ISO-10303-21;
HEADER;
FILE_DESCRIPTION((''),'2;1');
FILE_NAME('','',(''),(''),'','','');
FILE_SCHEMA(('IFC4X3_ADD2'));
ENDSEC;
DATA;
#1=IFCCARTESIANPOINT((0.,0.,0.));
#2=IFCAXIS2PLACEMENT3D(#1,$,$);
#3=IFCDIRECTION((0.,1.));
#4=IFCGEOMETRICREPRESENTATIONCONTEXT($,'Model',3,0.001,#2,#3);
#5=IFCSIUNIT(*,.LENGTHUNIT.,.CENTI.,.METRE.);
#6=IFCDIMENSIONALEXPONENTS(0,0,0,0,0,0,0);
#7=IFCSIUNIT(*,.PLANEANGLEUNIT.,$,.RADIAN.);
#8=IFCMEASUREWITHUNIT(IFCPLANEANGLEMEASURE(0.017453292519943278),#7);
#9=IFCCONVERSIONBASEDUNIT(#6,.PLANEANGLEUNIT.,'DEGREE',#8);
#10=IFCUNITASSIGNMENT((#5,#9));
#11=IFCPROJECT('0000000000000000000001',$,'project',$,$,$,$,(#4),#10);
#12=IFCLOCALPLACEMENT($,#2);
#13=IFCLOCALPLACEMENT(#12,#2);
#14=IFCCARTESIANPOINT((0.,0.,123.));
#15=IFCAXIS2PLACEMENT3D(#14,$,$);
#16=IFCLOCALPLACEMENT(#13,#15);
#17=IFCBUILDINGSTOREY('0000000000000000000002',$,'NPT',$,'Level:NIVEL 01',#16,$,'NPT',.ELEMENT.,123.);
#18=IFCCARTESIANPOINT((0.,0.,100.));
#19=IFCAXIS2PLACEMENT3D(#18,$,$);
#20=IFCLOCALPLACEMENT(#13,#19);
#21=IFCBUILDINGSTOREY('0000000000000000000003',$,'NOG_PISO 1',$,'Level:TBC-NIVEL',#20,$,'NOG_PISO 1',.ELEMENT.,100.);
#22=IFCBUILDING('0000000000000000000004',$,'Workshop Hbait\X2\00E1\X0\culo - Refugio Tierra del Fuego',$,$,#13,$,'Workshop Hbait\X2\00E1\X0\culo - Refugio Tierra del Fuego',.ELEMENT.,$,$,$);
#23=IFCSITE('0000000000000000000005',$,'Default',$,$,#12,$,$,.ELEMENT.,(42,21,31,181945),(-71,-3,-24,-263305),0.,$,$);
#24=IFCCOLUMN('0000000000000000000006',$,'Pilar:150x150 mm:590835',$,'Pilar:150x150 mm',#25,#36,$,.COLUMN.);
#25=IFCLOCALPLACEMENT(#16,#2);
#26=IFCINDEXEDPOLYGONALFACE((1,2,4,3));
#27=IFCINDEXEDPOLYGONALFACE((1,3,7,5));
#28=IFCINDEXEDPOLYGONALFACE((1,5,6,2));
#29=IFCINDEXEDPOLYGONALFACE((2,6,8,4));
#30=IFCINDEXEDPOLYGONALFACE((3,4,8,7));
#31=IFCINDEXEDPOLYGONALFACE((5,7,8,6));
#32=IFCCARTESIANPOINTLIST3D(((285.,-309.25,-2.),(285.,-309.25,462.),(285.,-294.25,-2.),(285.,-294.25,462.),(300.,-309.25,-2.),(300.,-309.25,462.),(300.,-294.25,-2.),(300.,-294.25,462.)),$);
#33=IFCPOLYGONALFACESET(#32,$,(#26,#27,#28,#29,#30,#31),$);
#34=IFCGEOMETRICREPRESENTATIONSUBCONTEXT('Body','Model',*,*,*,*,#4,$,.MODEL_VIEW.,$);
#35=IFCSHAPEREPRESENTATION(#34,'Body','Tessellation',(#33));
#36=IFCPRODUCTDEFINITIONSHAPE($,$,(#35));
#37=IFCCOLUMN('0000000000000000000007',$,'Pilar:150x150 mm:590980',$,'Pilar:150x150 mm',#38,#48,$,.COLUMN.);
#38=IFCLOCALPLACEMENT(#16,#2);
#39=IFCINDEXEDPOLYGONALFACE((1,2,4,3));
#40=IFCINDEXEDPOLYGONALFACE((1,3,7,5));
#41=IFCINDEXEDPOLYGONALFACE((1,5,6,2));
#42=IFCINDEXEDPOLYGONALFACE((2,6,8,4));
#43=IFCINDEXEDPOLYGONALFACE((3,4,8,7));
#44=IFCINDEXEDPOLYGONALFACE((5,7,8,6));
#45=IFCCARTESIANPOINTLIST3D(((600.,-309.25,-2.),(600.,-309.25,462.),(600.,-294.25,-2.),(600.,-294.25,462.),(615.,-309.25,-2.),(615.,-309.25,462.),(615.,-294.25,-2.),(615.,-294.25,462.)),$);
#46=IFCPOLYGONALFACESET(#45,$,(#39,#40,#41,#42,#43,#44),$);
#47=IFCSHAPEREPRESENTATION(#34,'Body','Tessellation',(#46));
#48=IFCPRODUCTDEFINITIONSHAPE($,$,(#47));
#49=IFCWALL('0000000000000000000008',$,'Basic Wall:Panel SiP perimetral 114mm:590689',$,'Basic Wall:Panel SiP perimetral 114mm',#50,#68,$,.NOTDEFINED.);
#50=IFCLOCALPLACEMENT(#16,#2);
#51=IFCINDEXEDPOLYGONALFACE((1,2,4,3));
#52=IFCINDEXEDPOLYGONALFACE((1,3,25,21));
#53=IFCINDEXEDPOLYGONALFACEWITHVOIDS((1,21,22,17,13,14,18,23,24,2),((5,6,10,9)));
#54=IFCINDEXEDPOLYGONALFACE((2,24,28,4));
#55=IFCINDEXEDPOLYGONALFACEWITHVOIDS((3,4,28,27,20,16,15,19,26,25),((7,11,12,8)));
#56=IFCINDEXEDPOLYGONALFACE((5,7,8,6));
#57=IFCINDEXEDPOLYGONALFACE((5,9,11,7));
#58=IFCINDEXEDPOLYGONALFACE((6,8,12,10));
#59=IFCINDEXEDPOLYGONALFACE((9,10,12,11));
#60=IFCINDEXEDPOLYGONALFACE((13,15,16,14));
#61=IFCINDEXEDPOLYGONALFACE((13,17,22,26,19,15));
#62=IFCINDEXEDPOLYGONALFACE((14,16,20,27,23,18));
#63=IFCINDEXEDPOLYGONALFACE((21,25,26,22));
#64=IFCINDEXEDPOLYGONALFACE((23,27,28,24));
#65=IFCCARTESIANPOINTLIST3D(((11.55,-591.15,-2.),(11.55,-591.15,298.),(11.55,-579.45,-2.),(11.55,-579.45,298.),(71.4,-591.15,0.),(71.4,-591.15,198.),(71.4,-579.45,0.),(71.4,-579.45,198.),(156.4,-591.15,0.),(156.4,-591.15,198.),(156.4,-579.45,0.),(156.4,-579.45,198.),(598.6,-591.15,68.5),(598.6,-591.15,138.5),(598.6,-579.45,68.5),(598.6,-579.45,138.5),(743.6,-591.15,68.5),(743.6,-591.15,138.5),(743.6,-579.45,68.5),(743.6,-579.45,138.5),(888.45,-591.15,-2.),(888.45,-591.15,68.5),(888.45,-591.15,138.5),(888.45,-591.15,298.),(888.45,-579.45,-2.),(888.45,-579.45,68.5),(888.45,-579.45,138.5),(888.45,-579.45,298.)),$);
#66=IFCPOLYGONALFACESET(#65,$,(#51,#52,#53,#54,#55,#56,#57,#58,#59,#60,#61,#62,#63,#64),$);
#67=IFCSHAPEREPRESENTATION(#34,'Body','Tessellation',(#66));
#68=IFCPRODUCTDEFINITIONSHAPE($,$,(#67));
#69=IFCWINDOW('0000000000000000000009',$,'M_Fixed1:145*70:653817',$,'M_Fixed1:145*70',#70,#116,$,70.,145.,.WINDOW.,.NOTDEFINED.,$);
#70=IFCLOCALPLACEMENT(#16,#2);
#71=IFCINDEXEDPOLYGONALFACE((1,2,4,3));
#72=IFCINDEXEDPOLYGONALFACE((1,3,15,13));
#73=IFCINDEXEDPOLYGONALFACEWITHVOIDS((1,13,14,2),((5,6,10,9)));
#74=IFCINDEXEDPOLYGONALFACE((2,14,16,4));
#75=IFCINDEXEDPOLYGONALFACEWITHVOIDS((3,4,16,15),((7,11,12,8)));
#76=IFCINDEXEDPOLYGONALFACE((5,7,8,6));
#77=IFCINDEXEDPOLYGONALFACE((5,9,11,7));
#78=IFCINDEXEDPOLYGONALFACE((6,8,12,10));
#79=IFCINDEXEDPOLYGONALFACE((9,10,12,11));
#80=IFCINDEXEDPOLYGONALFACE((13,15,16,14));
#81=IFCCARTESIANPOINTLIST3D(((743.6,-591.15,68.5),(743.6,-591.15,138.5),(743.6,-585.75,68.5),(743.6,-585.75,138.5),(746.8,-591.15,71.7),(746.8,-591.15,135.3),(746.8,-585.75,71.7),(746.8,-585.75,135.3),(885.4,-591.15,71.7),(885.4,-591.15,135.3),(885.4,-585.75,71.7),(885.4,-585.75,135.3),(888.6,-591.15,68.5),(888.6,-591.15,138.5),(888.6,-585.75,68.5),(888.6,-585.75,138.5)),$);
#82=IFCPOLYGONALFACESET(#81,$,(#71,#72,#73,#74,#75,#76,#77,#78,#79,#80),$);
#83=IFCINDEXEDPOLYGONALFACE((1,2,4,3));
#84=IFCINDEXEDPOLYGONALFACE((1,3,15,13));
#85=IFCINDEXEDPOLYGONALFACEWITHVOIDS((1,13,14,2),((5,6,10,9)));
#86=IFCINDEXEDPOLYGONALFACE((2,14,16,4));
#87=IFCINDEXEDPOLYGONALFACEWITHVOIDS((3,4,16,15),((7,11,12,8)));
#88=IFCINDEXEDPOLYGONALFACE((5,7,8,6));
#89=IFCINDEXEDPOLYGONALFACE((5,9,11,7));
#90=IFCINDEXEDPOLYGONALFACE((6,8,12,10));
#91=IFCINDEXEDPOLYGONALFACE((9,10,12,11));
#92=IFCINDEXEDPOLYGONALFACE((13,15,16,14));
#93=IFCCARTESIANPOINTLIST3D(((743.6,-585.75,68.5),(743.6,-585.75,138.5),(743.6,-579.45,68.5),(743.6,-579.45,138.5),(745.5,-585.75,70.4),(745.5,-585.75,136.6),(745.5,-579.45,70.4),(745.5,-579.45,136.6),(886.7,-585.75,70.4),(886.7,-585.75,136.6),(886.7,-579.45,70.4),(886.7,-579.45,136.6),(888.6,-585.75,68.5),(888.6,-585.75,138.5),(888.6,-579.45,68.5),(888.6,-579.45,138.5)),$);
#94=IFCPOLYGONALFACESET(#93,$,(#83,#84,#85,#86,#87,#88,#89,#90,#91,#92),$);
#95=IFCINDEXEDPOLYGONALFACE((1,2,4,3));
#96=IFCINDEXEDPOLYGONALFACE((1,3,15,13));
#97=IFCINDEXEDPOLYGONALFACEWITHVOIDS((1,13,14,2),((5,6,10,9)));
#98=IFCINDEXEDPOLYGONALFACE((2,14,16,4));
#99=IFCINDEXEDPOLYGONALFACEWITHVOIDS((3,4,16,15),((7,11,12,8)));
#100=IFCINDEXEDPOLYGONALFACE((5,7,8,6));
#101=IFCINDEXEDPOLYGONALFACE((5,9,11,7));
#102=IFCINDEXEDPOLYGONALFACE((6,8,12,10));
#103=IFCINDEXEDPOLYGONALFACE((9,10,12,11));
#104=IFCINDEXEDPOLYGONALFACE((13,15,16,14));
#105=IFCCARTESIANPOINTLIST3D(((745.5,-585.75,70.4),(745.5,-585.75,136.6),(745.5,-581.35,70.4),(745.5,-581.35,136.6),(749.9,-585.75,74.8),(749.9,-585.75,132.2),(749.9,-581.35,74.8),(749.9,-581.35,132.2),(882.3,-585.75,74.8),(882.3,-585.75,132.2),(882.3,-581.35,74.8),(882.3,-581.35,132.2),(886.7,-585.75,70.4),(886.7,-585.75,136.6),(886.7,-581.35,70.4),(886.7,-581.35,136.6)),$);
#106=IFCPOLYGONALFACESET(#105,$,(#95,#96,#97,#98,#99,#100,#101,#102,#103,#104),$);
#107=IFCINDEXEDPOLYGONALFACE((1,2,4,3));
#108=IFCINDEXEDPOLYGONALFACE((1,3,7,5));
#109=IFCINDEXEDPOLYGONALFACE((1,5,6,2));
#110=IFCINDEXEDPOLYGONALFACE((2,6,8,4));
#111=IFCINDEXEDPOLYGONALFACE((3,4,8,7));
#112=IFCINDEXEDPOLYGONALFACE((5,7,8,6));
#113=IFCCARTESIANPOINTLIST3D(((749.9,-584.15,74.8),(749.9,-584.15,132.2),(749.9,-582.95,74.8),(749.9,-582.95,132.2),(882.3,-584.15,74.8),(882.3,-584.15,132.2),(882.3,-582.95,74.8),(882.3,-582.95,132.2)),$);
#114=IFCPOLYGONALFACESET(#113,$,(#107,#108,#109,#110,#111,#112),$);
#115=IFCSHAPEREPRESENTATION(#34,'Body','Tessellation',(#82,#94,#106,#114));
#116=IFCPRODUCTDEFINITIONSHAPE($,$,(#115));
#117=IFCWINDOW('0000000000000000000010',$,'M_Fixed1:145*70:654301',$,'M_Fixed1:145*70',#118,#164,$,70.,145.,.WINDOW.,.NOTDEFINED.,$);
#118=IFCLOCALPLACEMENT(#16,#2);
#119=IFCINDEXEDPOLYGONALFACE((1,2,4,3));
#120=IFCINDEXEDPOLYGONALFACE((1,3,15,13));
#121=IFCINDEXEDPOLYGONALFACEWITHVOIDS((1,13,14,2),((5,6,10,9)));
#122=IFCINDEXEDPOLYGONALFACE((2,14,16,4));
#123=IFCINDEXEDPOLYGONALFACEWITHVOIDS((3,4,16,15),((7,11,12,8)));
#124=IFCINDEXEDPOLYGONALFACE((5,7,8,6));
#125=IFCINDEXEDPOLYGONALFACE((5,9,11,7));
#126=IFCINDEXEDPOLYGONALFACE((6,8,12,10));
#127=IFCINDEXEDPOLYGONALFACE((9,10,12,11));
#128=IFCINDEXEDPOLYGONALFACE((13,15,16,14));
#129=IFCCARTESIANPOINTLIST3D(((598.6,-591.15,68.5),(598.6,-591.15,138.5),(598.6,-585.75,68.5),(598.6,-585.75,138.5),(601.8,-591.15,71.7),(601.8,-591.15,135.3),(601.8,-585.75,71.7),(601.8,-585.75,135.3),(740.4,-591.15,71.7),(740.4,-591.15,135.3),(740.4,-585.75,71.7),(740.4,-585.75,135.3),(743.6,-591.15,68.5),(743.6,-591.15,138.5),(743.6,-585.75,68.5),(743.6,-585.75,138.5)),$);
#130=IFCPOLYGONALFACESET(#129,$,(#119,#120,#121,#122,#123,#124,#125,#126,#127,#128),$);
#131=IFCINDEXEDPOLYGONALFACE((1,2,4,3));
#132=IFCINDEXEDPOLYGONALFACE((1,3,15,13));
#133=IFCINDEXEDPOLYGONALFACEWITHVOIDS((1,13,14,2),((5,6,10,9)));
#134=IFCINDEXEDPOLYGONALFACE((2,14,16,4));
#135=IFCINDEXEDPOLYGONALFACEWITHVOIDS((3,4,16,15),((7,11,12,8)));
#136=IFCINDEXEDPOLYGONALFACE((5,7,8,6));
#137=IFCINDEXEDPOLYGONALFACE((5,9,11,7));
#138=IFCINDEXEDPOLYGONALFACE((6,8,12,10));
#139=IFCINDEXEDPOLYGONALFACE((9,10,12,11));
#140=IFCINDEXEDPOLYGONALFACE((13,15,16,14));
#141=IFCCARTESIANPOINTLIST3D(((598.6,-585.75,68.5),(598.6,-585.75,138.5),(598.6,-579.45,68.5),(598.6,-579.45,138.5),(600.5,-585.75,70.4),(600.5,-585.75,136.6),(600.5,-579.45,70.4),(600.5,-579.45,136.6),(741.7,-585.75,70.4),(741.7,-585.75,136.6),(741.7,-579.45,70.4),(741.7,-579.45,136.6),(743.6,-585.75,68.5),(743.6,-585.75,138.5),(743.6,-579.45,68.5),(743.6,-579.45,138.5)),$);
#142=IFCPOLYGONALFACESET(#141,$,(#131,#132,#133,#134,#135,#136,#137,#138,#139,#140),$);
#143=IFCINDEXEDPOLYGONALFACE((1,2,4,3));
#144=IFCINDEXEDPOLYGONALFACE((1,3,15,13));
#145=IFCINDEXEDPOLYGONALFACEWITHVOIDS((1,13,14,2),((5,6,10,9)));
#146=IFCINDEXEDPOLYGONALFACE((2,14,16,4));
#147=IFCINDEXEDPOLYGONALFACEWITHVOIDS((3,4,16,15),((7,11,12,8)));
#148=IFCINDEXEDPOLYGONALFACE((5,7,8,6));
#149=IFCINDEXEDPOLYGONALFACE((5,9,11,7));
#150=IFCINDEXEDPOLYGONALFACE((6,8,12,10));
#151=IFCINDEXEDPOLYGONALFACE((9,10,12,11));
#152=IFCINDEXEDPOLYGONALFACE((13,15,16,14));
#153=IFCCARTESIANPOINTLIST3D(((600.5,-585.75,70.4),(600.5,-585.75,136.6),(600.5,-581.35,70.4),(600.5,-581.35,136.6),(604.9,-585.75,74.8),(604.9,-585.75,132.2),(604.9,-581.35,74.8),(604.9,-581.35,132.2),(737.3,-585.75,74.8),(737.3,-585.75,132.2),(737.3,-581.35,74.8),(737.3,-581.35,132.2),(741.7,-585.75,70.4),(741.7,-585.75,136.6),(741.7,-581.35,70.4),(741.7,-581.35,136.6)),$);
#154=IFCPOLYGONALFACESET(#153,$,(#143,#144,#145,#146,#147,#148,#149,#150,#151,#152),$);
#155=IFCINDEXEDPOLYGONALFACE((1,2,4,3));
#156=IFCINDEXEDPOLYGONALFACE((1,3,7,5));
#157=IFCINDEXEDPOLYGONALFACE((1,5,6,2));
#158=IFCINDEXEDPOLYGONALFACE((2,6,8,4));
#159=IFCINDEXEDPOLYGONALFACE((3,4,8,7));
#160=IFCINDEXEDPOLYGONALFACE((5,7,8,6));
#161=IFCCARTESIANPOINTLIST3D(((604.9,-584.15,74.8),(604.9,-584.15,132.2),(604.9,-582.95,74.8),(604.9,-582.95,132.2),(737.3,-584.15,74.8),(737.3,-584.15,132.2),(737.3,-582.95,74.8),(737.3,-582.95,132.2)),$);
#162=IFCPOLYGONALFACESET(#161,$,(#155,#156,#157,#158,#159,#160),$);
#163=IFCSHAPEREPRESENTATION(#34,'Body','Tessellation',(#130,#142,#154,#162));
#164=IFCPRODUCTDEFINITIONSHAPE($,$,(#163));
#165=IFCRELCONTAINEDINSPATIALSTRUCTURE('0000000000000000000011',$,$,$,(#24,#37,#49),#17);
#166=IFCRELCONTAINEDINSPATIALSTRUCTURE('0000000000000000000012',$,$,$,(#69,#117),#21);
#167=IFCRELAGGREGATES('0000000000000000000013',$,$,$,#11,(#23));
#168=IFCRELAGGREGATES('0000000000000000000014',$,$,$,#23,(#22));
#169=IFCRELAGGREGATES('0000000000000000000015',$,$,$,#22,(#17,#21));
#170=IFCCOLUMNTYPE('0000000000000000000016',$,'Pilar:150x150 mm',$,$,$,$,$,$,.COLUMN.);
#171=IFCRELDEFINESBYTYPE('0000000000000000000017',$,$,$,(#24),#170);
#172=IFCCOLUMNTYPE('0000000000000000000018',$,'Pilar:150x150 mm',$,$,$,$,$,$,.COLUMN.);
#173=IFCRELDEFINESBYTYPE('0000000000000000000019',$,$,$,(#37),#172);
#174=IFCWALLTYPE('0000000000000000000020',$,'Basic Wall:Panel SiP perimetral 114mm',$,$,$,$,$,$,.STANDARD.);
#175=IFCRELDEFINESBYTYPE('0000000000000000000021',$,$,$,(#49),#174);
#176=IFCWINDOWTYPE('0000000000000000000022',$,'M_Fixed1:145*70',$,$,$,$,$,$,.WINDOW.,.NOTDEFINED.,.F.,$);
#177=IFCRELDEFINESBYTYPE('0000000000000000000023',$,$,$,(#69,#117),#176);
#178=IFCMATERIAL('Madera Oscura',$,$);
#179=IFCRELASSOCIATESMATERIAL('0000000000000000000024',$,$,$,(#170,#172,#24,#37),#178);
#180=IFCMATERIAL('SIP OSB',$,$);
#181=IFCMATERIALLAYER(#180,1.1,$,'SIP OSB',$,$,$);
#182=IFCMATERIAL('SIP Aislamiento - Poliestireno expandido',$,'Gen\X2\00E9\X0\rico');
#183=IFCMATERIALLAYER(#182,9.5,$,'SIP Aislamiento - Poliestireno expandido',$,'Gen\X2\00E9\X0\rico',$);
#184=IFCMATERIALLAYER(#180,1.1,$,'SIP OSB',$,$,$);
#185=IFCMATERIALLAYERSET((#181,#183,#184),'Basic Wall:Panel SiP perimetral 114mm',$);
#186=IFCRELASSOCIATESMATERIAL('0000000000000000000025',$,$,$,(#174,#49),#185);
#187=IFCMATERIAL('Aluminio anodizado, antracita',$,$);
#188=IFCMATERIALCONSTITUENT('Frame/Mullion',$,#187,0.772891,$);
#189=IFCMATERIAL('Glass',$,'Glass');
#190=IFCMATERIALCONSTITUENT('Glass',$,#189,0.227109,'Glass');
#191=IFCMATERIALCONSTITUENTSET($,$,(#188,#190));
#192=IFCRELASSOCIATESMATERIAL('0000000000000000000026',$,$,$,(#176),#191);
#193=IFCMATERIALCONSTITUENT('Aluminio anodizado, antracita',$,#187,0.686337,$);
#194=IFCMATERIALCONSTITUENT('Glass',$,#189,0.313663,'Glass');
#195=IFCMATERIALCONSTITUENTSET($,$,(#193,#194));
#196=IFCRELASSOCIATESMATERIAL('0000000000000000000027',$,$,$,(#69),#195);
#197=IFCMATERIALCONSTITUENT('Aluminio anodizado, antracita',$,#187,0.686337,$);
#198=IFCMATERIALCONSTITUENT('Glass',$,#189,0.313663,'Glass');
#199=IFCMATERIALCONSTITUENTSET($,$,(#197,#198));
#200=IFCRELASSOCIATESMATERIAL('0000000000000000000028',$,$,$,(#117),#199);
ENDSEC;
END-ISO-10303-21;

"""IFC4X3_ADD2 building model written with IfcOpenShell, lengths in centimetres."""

from ifc_helpers import new_model, entity, si_unit, converted_unit, direction, frame, frame_2d, origin, origin_2d_with_axis, place, context, subcontext, project, spatial, polyline, rectangle, outline, extrude, source, transform, mapped, material, layer, layer_set, constituent, constituent_set, material_profile, profile_set, profile_usage, type_object, type_shapes, element, fill, save


model = new_model("IFC4X3_ADD2")

# Units and contexts
model_context = context("Model", 3, precision=0.001, world=origin(), true_north=direction((0.0, 1.0)))
body_context = subcontext(model_context, "Body", "Model", "MODEL_VIEW")
ifc_project = project(units=[si_unit("LENGTHUNIT", "METRE", prefix="CENTI"), converted_unit("PLANEANGLEUNIT", "DEGREE", entity("IfcPlaneAngleMeasure", 0.017453292519943278), si_unit("PLANEANGLEUNIT", "RADIAN"), dimensions=[0, 0, 0, 0, 0, 0, 0])], contexts=[model_context])

# Site, building, storey
site_placement = place(None, origin())
site = spatial("IfcSite", under=ifc_project, at=site_placement, Name="Default", CompositionType="ELEMENT", RefLatitude=(42, 21, 31, 181945), RefLongitude=(-71, -3, -24, -263305), RefElevation=0.0)
building_placement = place(site_placement, origin())
building = spatial("IfcBuilding", under=site, at=building_placement, Name="Workshop Hbaitáculo - Refugio Tierra del Fuego", LongName="Workshop Hbaitáculo - Refugio Tierra del Fuego", CompositionType="ELEMENT")
storey_1_placement = place(building_placement, frame((0.0, 0.0, 123.0)))
storey_1 = spatial("IfcBuildingStorey", under=building, at=storey_1_placement, Name="NPT", ObjectType="Level:NIVEL 01", LongName="NPT", CompositionType="ELEMENT", Elevation=123.0)

# Columns
ifc_material_1 = material(Name="Madera Oscura")
ifc_material_profile = material_profile(ifc_material_1, rectangle(XDim=15.0, YDim=15.0, at=origin_2d_with_axis()), Name="150x150 mm")
ifc_profile_set = profile_set([ifc_material_profile], Name="150x150 mm")
ifc_profile_usage = profile_usage(ifc_profile_set)
column_type_1 = type_object("IfcColumnType", Name="Pilar:150x150 mm", PredefinedType="COLUMN", material=ifc_profile_set)
shared_shape_1 = source(origin(), body_context, "Body", "SweptSolid", [
    extrude(rectangle(XDim=15.0, YDim=15.0, at=origin_2d_with_axis()), frame((7.5, 7.5, 0.0), z_axis=(0.0, 0.0, 1.0), x_axis=(0.0, 1.0, 0.0)), (0.0, 0.0, 1.0), 464.0),
])
type_shapes(column_type_1, [shared_shape_1])
column_1_placement = place(storey_1_placement, frame((285.0, -309.25, -2.0)))
element("IfcColumn", 1, at=column_1_placement, inside=storey_1, type_object=column_type_1, material=ifc_profile_usage, Name="Pilar:150x150 mm:590835", ObjectType="Pilar:150x150 mm", PredefinedType="COLUMN", context=body_context, shape_type="MappedRepresentation", body=[
    mapped(shared_shape_1, transform((0.0, 0.0, 0.0), scale=1.0)),
])
column_type_2 = type_object("IfcColumnType", Name="Pilar:150x150 mm", PredefinedType="COLUMN", material=ifc_profile_set)
shared_shape_2 = source(origin(), body_context, "Body", "SweptSolid", [
    extrude(rectangle(XDim=15.0, YDim=15.0, at=origin_2d_with_axis()), frame((7.5, 7.5, 0.0), z_axis=(0.0, 0.0, 1.0), x_axis=(-1.0, 0.0, 0.0)), (0.0, 0.0, 1.0), 464.0),
])
type_shapes(column_type_2, [shared_shape_2])
column_2_placement = place(storey_1_placement, frame((615.0, -294.25, -2.0), z_axis=(0.0, 0.0, 1.0), x_axis=(-1.0, 0.0, 0.0)))
element("IfcColumn", 2, at=column_2_placement, inside=storey_1, type_object=column_type_2, material=ifc_profile_usage, Name="Pilar:150x150 mm:590980", ObjectType="Pilar:150x150 mm", PredefinedType="COLUMN", context=body_context, shape_type="MappedRepresentation", body=[
    mapped(shared_shape_2, transform((0.0, 0.0, 0.0), scale=1.0)),
])

# Wall, openings
ifc_material_2 = material(Name="SIP OSB")
ifc_layer_1 = layer(ifc_material_2, 1.1, Name="SIP OSB")
ifc_material_3 = material(Name="SIP Aislamiento - Poliestireno expandido", Category="Genérico")
ifc_layer_2 = layer(ifc_material_3, 9.5, Name="SIP Aislamiento - Poliestireno expandido", Category="Genérico")
ifc_layer_3 = layer(ifc_material_2, 1.1, Name="SIP OSB")
ifc_layer_set_1 = layer_set([ifc_layer_1, ifc_layer_2, ifc_layer_3], Name="Basic Wall:Panel SiP perimetral 114mm")
wall_type_1 = type_object("IfcWallType", Name="Basic Wall:Panel SiP perimetral 114mm", PredefinedType="STANDARD", material=ifc_layer_set_1)
wall_1_placement = place(storey_1_placement, frame((11.55, -585.3, -2.0)))
wall_1 = element("IfcWall", 3, at=wall_1_placement, inside=storey_1, type_object=wall_type_1, material=ifc_layer_set_1, Name="Basic Wall:Panel SiP perimetral 114mm:590689", ObjectType="Basic Wall:Panel SiP perimetral 114mm", PredefinedType="NOTDEFINED", context=body_context, shape_type="SweptSolid", body=[
    extrude(rectangle(XDim=876.9, YDim=11.7, at=frame_2d((438.45, 0.0), x_axis=(-1.0, 0.0))), origin(), (0.0, 0.0, 1.0), 300.0),
])
opening_1_placement = place(wall_1_placement, frame((732.05, -5.85, 70.5)))
opening_1 = element("IfcOpeningElement", 4, at=opening_1_placement, cuts=wall_1, PredefinedType="OPENING", context=body_context, shape_type="SweptSolid", body=[
    extrude(rectangle(XDim=70.0, YDim=145.0, at=frame_2d((35.0, 72.5), x_axis=(1.0, 0.0))), frame((0.0, 0.0, 0.0), z_axis=(0.0, 1.0, 0.0), x_axis=(0.0, 0.0, 1.0)), (0.0, 0.0, 1.0), 11.7),
])
opening_2_placement = place(wall_1_placement, frame((587.05, -5.85, 70.5)))
opening_2 = element("IfcOpeningElement", 5, at=opening_2_placement, cuts=wall_1, PredefinedType="OPENING", context=body_context, shape_type="SweptSolid", body=[
    extrude(rectangle(XDim=70.0, YDim=145.0, at=frame_2d((35.0, 72.5), x_axis=(1.0, 0.0))), frame((0.0, 0.0, 0.0), z_axis=(0.0, 1.0, 0.0), x_axis=(0.0, 0.0, 1.0)), (0.0, 0.0, 1.0), 11.7),
])
opening_3_placement = place(wall_1_placement, frame((59.85, -5.85, 2.0)))
element("IfcOpeningElement", 6, at=opening_3_placement, cuts=wall_1, PredefinedType="OPENING", context=body_context, shape_type="SweptSolid", body=[
    extrude(rectangle(XDim=198.0, YDim=85.0, at=frame_2d((99.0, 42.5), x_axis=(1.0, 0.0))), frame((0.0, 0.0, 0.0), z_axis=(0.0, 1.0, 0.0), x_axis=(0.0, 0.0, 1.0)), (0.0, 0.0, 1.0), 11.7),
])

# Shared definitions
storey_2_placement = place(building_placement, frame((0.0, 0.0, 100.0)))
storey_2 = spatial("IfcBuildingStorey", under=building, at=storey_2_placement, Name="NOG_PISO 1", ObjectType="Level:TBC-NIVEL", LongName="NOG_PISO 1", CompositionType="ELEMENT", Elevation=100.0)

# Windows
ifc_material_4 = material(Name="Aluminio anodizado, antracita")
ifc_constituent_1 = constituent(ifc_material_4, Name="Aluminio anodizado, antracita", fraction=0.686337)
ifc_material_5 = material(Name="Glass", Category="Glass")
ifc_constituent_2 = constituent(ifc_material_5, Name="Glass", Category="Glass", fraction=0.313663)
ifc_constituent_set_1 = constituent_set(constituents=[ifc_constituent_1, ifc_constituent_2])
ifc_constituent_3 = constituent(ifc_material_4, Name="Frame/Mullion", fraction=0.772891)
ifc_constituent_4 = constituent(ifc_material_5, Name="Glass", Category="Glass", fraction=0.227109)
ifc_constituent_set_2 = constituent_set(constituents=[ifc_constituent_3, ifc_constituent_4])
window_type = type_object("IfcWindowType", Name="M_Fixed1:145*70", ParameterTakesPrecedence=False, PartitioningType="NOTDEFINED", PredefinedType="WINDOW", material=ifc_constituent_set_2)
shared_shape_3 = source(origin(), body_context, "Body", "SweptSolid", [
    extrude(outline(polyline([(-72.5, -35.0), (72.5, -35.0), (72.5, 35.0), (-72.5, 35.0), (-72.5, -35.0)]), holes=[polyline([(-69.3, -31.8), (-69.3, 31.8), (69.3, 31.8), (69.3, -31.8), (-69.3, -31.8)])]), frame((72.5, 0.0, 35.0), z_axis=(0.0, 1.0, 0.0), x_axis=(1.0, 0.0, 0.0)), (0.0, 0.0, 1.0), 5.4),
    extrude(outline(polyline([(-72.5, -35.0), (72.5, -35.0), (72.5, 35.0), (-72.5, 35.0), (-72.5, -35.0)]), holes=[polyline([(-70.6, -33.1), (-70.6, 33.1), (70.6, 33.1), (70.6, -33.1), (-70.6, -33.1)])]), frame((72.5, 5.4, 35.0), z_axis=(0.0, 1.0, 0.0), x_axis=(1.0, 0.0, 0.0)), (0.0, 0.0, 1.0), 6.3),
    extrude(outline(polyline([(-70.6, -33.1), (70.6, -33.1), (70.6, 33.1), (-70.6, 33.1), (-70.6, -33.1)]), holes=[polyline([(-66.2, -28.7), (-66.2, 28.7), (66.2, 28.7), (66.2, -28.7), (-66.2, -28.7)])]), frame((72.5, 5.4, 35.0), z_axis=(0.0, 1.0, 0.0), x_axis=(1.0, 0.0, 0.0)), (0.0, 0.0, 1.0), 4.4),
    extrude(rectangle(XDim=1.2, YDim=132.4, at=origin_2d_with_axis()), frame((72.5, 7.6, 6.3), z_axis=(0.0, 0.0, 1.0), x_axis=(0.0, -1.0, 0.0)), (0.0, 0.0, 1.0), 57.4),
])
type_shapes(window_type, [shared_shape_3])
window_1_placement = place(opening_1_placement, origin())
window_1 = element("IfcWindow", 7, at=window_1_placement, inside=storey_2, type_object=window_type, material=ifc_constituent_set_1, Name="M_Fixed1:145*70:653817", ObjectType="M_Fixed1:145*70", OverallHeight=70.0, OverallWidth=145.0, PartitioningType="NOTDEFINED", PredefinedType="WINDOW", context=body_context, shape_type="MappedRepresentation", body=[
    mapped(shared_shape_3, transform((0.0, 0.0, 0.0), scale=1.0)),
])
fill(opening_1, window_1)
ifc_constituent_5 = constituent(ifc_material_4, Name="Aluminio anodizado, antracita", fraction=0.686337)
ifc_constituent_6 = constituent(ifc_material_5, Name="Glass", Category="Glass", fraction=0.313663)
ifc_constituent_set_3 = constituent_set(constituents=[ifc_constituent_5, ifc_constituent_6])
window_2_placement = place(opening_2_placement, origin())
window_2 = element("IfcWindow", 8, at=window_2_placement, inside=storey_2, type_object=window_type, material=ifc_constituent_set_3, Name="M_Fixed1:145*70:654301", ObjectType="M_Fixed1:145*70", OverallHeight=70.0, OverallWidth=145.0, PartitioningType="NOTDEFINED", PredefinedType="WINDOW", context=body_context, shape_type="MappedRepresentation", body=[
    mapped(shared_shape_3, transform((0.0, 0.0, 0.0), scale=1.0)),
])
fill(opening_2, window_2)

save(model, "model.ifc")
